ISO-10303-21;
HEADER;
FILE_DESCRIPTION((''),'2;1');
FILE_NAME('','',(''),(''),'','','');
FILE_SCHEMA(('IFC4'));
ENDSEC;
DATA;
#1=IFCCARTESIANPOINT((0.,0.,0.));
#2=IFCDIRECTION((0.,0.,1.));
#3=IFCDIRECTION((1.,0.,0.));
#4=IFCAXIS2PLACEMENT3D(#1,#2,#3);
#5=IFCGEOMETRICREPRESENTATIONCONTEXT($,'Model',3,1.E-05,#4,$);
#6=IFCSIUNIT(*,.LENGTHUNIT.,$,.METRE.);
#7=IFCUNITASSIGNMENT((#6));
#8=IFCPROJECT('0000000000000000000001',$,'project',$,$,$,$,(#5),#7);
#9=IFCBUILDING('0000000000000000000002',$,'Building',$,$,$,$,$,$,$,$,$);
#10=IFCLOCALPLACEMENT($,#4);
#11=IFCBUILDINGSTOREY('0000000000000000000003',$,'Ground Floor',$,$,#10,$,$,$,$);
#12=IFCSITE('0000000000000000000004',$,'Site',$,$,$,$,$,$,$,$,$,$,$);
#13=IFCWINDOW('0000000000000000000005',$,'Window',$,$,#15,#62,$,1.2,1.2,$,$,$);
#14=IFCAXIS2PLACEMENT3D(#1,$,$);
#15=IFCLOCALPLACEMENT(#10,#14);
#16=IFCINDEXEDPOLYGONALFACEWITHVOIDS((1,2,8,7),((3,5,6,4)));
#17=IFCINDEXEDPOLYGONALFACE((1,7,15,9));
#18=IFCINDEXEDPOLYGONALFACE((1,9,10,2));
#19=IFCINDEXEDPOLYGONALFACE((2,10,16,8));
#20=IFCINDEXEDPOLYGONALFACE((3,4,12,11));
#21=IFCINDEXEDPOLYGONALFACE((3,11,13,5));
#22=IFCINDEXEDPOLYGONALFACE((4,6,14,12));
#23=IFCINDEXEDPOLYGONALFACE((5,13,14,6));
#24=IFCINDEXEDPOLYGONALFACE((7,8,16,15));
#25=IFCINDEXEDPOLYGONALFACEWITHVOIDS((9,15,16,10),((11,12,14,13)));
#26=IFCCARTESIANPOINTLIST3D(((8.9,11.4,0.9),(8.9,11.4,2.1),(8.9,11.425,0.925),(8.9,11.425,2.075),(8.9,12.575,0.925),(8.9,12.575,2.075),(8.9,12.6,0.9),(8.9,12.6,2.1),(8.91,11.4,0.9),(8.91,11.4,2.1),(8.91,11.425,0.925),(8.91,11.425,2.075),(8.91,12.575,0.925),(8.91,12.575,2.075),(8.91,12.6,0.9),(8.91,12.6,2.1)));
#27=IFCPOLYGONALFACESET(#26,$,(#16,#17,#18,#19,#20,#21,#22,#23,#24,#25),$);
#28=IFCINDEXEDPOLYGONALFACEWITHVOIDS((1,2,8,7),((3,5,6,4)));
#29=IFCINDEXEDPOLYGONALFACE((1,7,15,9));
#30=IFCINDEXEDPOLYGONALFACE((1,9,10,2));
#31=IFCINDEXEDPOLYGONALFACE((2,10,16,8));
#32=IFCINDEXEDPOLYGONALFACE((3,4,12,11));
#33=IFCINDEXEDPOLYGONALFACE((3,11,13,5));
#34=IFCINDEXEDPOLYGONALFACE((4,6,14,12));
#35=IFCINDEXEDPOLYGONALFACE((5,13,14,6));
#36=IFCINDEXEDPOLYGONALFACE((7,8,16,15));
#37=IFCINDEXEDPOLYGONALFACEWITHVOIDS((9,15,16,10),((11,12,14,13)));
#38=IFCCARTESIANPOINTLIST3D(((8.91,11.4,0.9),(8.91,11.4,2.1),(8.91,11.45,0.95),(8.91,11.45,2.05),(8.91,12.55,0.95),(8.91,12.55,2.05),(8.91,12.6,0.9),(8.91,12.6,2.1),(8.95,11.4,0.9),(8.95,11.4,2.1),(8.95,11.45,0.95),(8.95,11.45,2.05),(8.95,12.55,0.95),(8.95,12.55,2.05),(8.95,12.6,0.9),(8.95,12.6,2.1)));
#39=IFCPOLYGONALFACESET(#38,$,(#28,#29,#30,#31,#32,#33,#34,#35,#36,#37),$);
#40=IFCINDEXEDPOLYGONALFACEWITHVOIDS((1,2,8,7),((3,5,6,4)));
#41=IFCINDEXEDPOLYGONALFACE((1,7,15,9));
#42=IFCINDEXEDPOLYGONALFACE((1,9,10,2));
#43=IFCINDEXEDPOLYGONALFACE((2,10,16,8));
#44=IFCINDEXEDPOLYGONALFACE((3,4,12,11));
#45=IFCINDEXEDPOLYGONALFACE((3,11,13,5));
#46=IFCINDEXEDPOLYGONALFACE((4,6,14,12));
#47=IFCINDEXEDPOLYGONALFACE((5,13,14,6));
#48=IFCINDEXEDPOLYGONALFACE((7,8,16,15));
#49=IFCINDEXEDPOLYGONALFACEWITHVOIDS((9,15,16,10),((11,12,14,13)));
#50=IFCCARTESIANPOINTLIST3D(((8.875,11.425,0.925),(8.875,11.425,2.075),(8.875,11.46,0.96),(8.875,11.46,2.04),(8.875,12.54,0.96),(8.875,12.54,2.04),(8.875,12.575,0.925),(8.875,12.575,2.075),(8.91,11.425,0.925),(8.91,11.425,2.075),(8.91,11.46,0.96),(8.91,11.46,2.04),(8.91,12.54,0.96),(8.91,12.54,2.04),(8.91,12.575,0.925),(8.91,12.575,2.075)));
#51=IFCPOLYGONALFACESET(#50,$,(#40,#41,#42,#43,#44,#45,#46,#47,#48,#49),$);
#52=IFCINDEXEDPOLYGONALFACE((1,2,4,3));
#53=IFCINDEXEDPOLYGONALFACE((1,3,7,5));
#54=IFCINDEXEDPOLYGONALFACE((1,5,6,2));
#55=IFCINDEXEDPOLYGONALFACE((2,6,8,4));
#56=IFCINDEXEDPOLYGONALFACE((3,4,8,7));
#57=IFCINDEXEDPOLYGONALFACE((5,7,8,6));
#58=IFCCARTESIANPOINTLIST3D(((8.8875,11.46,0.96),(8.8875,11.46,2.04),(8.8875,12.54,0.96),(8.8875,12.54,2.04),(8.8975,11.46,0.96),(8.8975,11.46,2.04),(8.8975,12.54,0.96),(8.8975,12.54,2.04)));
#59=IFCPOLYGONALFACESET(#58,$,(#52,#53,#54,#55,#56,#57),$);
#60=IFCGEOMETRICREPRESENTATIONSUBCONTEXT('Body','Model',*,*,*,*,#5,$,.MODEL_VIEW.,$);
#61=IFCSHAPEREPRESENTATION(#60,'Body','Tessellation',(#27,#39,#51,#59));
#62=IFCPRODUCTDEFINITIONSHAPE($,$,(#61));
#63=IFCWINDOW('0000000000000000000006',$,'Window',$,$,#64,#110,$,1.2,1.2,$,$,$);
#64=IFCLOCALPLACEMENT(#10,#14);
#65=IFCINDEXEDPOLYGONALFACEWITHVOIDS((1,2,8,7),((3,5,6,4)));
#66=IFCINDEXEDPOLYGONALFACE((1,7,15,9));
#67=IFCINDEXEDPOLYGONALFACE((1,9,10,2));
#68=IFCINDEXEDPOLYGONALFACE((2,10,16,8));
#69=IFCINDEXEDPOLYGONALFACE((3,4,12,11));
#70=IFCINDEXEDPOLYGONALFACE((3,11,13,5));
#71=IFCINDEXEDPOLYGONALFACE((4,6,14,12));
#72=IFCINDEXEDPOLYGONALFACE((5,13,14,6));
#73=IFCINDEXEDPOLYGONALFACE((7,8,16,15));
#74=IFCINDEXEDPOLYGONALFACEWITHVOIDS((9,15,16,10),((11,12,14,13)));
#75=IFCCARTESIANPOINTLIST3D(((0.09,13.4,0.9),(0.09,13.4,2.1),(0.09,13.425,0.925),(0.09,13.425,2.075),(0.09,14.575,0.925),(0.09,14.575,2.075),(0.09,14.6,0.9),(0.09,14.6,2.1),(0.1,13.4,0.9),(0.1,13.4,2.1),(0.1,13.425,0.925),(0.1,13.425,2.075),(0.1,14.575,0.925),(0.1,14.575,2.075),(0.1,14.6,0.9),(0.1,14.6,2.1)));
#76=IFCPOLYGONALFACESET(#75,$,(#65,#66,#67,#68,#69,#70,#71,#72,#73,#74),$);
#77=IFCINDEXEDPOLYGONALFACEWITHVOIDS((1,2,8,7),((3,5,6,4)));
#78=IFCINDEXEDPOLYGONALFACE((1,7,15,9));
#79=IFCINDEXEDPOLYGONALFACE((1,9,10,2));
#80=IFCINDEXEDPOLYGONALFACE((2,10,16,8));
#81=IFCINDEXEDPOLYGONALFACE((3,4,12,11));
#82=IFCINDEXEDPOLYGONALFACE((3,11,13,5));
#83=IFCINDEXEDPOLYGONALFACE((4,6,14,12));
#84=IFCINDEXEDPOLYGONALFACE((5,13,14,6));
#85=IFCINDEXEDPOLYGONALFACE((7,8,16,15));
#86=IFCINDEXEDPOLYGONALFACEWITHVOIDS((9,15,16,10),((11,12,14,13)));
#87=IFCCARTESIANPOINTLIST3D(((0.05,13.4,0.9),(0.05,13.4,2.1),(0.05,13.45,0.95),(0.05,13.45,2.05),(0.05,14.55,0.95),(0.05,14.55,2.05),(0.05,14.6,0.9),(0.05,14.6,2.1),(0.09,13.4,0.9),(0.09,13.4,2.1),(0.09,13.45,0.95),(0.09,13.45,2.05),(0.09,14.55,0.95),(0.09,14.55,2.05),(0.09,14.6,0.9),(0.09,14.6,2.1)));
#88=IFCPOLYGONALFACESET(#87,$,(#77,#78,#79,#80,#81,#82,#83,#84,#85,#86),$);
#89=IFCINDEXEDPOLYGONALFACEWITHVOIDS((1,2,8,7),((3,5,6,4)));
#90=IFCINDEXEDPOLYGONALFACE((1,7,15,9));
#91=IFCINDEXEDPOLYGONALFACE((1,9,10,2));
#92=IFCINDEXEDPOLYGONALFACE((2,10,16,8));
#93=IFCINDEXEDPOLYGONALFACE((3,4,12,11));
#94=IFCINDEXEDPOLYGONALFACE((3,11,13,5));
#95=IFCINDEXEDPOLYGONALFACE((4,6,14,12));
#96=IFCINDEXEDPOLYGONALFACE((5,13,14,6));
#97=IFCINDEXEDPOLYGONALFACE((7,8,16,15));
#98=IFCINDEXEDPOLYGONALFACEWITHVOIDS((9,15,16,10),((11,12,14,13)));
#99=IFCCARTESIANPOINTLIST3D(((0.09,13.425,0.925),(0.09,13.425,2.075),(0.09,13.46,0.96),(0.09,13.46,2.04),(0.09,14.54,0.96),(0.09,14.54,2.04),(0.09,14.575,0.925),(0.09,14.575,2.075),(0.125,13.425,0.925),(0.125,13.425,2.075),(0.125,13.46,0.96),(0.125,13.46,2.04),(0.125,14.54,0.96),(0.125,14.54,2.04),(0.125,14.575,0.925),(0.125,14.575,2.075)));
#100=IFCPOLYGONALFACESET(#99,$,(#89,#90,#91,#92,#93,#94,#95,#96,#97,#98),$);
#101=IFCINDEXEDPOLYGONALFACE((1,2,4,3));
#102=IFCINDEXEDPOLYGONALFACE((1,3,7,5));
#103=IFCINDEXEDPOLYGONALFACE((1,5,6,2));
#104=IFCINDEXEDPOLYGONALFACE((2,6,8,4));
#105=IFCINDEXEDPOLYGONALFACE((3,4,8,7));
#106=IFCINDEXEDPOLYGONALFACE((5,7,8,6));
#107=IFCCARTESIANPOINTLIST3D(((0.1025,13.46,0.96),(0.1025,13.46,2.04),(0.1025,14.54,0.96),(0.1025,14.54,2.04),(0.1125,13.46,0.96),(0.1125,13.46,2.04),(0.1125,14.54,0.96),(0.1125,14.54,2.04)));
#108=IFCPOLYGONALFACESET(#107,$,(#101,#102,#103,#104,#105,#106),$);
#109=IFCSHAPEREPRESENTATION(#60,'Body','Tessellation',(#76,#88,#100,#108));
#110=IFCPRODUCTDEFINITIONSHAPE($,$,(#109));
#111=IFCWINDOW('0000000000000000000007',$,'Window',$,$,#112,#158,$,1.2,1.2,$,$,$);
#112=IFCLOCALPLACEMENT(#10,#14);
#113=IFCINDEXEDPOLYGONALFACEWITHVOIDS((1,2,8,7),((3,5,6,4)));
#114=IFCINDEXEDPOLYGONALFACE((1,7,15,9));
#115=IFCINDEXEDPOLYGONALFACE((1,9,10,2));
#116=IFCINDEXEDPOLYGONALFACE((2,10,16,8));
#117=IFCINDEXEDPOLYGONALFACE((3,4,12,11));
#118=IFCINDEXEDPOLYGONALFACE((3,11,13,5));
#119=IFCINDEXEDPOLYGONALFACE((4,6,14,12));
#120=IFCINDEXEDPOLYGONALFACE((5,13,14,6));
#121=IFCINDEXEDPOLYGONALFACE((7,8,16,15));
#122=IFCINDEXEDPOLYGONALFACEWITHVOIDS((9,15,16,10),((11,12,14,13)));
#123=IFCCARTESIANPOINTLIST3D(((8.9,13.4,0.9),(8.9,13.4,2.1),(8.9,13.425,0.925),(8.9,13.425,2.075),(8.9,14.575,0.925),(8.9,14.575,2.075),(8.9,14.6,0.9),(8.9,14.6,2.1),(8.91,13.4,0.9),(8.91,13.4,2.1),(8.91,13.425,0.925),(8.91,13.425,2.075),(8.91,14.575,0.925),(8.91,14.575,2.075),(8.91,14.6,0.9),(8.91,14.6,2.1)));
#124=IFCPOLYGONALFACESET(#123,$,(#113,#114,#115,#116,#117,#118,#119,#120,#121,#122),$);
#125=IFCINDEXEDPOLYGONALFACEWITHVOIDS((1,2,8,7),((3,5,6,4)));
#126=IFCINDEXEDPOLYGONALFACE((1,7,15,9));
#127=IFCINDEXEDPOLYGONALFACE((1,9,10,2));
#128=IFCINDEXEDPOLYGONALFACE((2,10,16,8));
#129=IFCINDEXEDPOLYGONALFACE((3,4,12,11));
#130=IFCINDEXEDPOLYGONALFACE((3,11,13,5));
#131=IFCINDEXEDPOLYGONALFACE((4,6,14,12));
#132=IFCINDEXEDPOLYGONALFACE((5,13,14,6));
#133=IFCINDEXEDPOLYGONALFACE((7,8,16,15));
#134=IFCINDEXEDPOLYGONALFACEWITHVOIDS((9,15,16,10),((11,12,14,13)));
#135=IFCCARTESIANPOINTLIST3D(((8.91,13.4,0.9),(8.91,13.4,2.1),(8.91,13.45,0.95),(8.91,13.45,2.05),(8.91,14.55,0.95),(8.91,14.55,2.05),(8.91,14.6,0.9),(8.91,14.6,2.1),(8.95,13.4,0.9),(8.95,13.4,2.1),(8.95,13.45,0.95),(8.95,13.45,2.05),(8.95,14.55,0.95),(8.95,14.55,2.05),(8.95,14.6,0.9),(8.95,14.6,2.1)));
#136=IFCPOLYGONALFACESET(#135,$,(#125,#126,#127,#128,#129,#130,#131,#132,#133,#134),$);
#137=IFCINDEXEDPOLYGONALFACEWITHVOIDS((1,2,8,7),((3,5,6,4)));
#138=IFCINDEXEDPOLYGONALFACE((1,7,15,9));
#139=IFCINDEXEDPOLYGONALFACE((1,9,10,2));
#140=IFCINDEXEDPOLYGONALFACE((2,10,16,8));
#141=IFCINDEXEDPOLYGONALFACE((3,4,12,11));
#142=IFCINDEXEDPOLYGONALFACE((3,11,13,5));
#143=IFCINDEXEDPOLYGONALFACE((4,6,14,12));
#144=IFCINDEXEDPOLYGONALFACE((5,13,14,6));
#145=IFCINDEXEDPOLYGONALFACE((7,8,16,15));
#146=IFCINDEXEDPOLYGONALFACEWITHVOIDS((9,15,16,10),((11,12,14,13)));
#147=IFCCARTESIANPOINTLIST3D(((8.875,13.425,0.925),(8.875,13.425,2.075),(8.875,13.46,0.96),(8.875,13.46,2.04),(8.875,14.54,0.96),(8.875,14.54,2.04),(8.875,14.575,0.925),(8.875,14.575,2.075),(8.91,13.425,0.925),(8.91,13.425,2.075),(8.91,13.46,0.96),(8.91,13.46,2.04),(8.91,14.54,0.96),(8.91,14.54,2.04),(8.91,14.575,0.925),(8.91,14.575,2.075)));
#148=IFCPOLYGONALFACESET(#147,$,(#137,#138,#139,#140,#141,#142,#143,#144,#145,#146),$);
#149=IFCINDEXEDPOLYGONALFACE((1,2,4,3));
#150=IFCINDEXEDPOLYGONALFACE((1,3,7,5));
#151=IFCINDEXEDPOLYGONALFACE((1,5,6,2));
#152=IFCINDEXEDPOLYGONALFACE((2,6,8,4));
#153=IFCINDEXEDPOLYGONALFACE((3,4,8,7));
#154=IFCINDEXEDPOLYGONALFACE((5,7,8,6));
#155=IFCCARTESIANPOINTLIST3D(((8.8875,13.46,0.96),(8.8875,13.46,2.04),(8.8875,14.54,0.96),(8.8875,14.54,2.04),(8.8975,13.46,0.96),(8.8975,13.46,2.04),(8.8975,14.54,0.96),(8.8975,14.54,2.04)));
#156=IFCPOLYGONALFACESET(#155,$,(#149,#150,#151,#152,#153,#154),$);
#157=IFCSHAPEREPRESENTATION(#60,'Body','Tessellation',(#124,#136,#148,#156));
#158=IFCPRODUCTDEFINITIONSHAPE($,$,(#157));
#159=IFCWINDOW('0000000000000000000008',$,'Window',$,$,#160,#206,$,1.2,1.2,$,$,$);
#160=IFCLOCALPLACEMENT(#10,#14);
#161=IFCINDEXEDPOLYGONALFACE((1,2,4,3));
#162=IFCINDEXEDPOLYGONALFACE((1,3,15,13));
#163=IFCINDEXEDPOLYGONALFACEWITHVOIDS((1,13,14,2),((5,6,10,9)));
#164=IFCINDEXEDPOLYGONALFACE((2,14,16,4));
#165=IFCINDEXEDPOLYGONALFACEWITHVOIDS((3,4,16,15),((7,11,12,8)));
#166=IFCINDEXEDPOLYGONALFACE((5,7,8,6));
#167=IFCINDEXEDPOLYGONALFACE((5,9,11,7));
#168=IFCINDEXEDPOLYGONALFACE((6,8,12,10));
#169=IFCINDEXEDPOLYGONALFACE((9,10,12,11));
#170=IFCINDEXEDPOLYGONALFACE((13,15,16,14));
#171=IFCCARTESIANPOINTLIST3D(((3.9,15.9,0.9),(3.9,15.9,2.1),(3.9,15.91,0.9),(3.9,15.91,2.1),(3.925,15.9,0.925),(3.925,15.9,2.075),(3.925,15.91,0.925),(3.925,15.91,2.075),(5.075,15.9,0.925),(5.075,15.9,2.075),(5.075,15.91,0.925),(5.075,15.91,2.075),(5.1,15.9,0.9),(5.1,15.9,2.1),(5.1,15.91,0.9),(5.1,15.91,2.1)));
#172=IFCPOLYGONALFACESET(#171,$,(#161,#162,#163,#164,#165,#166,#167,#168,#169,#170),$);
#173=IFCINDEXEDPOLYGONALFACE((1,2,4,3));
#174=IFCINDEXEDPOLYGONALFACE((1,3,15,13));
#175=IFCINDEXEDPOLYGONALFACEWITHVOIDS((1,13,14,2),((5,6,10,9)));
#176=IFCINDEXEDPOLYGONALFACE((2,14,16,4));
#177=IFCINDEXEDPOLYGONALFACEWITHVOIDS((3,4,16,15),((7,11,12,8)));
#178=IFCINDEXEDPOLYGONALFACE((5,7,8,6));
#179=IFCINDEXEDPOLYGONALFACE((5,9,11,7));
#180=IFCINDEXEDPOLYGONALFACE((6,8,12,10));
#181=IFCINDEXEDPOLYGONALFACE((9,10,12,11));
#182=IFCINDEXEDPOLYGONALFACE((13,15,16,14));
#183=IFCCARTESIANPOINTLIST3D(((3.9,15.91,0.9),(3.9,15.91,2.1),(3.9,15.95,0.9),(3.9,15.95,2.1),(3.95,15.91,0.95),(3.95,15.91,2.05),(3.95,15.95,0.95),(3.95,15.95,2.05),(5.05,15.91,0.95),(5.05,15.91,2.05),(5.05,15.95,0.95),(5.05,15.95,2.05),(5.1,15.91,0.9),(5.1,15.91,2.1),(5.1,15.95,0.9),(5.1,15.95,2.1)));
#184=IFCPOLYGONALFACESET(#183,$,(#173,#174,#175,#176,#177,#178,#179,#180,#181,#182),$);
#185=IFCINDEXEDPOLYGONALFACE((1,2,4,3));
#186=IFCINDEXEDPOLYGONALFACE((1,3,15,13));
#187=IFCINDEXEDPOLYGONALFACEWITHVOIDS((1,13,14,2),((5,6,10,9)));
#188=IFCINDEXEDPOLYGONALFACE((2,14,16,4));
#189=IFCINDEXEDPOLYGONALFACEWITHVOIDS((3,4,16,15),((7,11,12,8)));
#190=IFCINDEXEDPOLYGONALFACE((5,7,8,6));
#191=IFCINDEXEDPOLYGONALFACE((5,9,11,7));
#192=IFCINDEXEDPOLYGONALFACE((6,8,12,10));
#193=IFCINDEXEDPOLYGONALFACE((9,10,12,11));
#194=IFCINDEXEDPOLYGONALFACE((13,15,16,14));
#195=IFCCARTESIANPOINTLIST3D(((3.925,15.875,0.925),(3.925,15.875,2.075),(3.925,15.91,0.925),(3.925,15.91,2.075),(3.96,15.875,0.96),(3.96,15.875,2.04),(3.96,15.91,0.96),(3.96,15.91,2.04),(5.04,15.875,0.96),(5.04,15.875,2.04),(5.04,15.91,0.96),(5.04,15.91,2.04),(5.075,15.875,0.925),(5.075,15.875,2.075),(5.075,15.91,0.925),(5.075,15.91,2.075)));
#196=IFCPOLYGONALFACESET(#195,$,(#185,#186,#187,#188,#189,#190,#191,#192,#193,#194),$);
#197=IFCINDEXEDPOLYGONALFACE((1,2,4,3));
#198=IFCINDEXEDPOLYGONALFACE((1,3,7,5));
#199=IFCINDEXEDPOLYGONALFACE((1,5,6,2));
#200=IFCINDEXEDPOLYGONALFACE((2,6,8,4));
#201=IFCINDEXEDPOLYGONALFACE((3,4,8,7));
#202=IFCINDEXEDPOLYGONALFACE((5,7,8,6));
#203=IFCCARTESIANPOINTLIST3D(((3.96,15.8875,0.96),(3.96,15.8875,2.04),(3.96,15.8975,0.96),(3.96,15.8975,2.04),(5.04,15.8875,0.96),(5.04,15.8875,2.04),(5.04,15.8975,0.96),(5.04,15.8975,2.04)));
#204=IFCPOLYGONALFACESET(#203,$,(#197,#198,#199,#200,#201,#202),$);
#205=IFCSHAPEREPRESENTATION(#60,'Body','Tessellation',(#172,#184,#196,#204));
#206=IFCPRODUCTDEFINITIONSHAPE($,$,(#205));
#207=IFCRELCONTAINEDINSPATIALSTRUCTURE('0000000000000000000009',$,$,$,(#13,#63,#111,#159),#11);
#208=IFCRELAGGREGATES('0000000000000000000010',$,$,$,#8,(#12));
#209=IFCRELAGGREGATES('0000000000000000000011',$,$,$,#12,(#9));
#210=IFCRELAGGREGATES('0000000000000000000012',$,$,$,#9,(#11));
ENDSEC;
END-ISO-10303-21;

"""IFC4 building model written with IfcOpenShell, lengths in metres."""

from ifc_helpers import new_model, si_unit, frame, origin_with_axes, place, context, subcontext, project, spatial, line, indexed_curve, outline, extrude, element, save


model = new_model("IFC4")

# Units and contexts
model_context = context("Model", 3, precision=1e-05, world=origin_with_axes())
body_context = subcontext(model_context, "Body", "Model", "MODEL_VIEW")
ifc_project = project(units=[si_unit("LENGTHUNIT", "METRE")], contexts=[model_context])

# Site, building, storey
site = spatial("IfcSite", under=ifc_project, Name="Site")
building = spatial("IfcBuilding", under=site, Name="Building")
storey_placement = place(None, origin_with_axes())
storey = spatial("IfcBuildingStorey", under=building, at=storey_placement, Name="Ground Floor")

# Windows
for number, where, z_axis, x_axis, name in (
    (1, (9.0, 11.4, 0.9), (0.0, 0.0, 1.0), (0.0, 1.0, 0.0), "Window"),
    (2, (0.0, 14.6, 0.9), (0.0, 0.0, 1.0), (0.0, -1.0, 0.0), "Window"),
    (3, (9.0, 13.4, 0.9), (0.0, 0.0, 1.0), (0.0, 1.0, 0.0), "Window"),
    (4, (5.1, 16.0, 0.9), (0.0, 0.0, 1.0), (-1.0, 0.0, 0.0), "Window"),
):
    element("IfcWindow", number, at=place(storey_placement, frame(where, z_axis=z_axis, x_axis=x_axis)), inside=storey, Name=name, OverallHeight=1.2, OverallWidth=1.2, context=body_context, shape_type="SweptSolid", body=[
        extrude(outline(indexed_curve([(0.0, 0.0), (1.2, 0.0), (1.2, 1.2), (0.0, 1.2)], segments=[line(1, 2, 3, 4, 1)]), holes=[indexed_curve([(0.025, 0.025), (1.175, 0.025), (1.175, 1.175), (0.025, 1.175)], segments=[line(1, 2, 3, 4, 1)])]), frame((0.0, 0.09, 0.0), z_axis=(0.0, -1.0, 0.0), x_axis=(1.0, 0.0, 0.0)), (0.0, 0.0, -1.0), 0.01),
        extrude(outline(indexed_curve([(0.0, 0.0), (1.2, 0.0), (1.2, 1.2), (0.0, 1.2)], segments=[line(1, 2, 3, 4, 1)]), holes=[indexed_curve([(0.05, 0.05), (1.15, 0.05), (1.15, 1.15), (0.05, 1.15)], segments=[line(1, 2, 3, 4, 1)])]), frame((0.0, 0.05, 0.0), z_axis=(0.0, -1.0, 0.0), x_axis=(1.0, 0.0, 0.0)), (0.0, 0.0, -1.0), 0.04),
        extrude(outline(indexed_curve([(0.0, 0.0), (1.15, 0.0), (1.15, 1.15), (0.0, 1.15)], segments=[line(1, 2, 3, 4, 1)]), holes=[indexed_curve([(0.035, 0.035), (1.115, 0.035), (1.115, 1.115), (0.035, 1.115)], segments=[line(1, 2, 3, 4, 1)])]), frame((0.025, 0.09, 0.025), z_axis=(0.0, -1.0, 0.0), x_axis=(1.0, 0.0, 0.0)), (0.0, 0.0, -1.0), 0.035),
        extrude(outline(indexed_curve([(0.035, 0.035), (1.115, 0.035), (1.115, 1.115), (0.035, 1.115)], segments=[line(1, 2, 3, 4, 1)])), frame((0.025, 0.1025, 0.025), z_axis=(0.0, -1.0, 0.0), x_axis=(1.0, 0.0, 0.0)), (0.0, 0.0, -1.0), 0.01),
    ])

save(model, "model.ifc")
